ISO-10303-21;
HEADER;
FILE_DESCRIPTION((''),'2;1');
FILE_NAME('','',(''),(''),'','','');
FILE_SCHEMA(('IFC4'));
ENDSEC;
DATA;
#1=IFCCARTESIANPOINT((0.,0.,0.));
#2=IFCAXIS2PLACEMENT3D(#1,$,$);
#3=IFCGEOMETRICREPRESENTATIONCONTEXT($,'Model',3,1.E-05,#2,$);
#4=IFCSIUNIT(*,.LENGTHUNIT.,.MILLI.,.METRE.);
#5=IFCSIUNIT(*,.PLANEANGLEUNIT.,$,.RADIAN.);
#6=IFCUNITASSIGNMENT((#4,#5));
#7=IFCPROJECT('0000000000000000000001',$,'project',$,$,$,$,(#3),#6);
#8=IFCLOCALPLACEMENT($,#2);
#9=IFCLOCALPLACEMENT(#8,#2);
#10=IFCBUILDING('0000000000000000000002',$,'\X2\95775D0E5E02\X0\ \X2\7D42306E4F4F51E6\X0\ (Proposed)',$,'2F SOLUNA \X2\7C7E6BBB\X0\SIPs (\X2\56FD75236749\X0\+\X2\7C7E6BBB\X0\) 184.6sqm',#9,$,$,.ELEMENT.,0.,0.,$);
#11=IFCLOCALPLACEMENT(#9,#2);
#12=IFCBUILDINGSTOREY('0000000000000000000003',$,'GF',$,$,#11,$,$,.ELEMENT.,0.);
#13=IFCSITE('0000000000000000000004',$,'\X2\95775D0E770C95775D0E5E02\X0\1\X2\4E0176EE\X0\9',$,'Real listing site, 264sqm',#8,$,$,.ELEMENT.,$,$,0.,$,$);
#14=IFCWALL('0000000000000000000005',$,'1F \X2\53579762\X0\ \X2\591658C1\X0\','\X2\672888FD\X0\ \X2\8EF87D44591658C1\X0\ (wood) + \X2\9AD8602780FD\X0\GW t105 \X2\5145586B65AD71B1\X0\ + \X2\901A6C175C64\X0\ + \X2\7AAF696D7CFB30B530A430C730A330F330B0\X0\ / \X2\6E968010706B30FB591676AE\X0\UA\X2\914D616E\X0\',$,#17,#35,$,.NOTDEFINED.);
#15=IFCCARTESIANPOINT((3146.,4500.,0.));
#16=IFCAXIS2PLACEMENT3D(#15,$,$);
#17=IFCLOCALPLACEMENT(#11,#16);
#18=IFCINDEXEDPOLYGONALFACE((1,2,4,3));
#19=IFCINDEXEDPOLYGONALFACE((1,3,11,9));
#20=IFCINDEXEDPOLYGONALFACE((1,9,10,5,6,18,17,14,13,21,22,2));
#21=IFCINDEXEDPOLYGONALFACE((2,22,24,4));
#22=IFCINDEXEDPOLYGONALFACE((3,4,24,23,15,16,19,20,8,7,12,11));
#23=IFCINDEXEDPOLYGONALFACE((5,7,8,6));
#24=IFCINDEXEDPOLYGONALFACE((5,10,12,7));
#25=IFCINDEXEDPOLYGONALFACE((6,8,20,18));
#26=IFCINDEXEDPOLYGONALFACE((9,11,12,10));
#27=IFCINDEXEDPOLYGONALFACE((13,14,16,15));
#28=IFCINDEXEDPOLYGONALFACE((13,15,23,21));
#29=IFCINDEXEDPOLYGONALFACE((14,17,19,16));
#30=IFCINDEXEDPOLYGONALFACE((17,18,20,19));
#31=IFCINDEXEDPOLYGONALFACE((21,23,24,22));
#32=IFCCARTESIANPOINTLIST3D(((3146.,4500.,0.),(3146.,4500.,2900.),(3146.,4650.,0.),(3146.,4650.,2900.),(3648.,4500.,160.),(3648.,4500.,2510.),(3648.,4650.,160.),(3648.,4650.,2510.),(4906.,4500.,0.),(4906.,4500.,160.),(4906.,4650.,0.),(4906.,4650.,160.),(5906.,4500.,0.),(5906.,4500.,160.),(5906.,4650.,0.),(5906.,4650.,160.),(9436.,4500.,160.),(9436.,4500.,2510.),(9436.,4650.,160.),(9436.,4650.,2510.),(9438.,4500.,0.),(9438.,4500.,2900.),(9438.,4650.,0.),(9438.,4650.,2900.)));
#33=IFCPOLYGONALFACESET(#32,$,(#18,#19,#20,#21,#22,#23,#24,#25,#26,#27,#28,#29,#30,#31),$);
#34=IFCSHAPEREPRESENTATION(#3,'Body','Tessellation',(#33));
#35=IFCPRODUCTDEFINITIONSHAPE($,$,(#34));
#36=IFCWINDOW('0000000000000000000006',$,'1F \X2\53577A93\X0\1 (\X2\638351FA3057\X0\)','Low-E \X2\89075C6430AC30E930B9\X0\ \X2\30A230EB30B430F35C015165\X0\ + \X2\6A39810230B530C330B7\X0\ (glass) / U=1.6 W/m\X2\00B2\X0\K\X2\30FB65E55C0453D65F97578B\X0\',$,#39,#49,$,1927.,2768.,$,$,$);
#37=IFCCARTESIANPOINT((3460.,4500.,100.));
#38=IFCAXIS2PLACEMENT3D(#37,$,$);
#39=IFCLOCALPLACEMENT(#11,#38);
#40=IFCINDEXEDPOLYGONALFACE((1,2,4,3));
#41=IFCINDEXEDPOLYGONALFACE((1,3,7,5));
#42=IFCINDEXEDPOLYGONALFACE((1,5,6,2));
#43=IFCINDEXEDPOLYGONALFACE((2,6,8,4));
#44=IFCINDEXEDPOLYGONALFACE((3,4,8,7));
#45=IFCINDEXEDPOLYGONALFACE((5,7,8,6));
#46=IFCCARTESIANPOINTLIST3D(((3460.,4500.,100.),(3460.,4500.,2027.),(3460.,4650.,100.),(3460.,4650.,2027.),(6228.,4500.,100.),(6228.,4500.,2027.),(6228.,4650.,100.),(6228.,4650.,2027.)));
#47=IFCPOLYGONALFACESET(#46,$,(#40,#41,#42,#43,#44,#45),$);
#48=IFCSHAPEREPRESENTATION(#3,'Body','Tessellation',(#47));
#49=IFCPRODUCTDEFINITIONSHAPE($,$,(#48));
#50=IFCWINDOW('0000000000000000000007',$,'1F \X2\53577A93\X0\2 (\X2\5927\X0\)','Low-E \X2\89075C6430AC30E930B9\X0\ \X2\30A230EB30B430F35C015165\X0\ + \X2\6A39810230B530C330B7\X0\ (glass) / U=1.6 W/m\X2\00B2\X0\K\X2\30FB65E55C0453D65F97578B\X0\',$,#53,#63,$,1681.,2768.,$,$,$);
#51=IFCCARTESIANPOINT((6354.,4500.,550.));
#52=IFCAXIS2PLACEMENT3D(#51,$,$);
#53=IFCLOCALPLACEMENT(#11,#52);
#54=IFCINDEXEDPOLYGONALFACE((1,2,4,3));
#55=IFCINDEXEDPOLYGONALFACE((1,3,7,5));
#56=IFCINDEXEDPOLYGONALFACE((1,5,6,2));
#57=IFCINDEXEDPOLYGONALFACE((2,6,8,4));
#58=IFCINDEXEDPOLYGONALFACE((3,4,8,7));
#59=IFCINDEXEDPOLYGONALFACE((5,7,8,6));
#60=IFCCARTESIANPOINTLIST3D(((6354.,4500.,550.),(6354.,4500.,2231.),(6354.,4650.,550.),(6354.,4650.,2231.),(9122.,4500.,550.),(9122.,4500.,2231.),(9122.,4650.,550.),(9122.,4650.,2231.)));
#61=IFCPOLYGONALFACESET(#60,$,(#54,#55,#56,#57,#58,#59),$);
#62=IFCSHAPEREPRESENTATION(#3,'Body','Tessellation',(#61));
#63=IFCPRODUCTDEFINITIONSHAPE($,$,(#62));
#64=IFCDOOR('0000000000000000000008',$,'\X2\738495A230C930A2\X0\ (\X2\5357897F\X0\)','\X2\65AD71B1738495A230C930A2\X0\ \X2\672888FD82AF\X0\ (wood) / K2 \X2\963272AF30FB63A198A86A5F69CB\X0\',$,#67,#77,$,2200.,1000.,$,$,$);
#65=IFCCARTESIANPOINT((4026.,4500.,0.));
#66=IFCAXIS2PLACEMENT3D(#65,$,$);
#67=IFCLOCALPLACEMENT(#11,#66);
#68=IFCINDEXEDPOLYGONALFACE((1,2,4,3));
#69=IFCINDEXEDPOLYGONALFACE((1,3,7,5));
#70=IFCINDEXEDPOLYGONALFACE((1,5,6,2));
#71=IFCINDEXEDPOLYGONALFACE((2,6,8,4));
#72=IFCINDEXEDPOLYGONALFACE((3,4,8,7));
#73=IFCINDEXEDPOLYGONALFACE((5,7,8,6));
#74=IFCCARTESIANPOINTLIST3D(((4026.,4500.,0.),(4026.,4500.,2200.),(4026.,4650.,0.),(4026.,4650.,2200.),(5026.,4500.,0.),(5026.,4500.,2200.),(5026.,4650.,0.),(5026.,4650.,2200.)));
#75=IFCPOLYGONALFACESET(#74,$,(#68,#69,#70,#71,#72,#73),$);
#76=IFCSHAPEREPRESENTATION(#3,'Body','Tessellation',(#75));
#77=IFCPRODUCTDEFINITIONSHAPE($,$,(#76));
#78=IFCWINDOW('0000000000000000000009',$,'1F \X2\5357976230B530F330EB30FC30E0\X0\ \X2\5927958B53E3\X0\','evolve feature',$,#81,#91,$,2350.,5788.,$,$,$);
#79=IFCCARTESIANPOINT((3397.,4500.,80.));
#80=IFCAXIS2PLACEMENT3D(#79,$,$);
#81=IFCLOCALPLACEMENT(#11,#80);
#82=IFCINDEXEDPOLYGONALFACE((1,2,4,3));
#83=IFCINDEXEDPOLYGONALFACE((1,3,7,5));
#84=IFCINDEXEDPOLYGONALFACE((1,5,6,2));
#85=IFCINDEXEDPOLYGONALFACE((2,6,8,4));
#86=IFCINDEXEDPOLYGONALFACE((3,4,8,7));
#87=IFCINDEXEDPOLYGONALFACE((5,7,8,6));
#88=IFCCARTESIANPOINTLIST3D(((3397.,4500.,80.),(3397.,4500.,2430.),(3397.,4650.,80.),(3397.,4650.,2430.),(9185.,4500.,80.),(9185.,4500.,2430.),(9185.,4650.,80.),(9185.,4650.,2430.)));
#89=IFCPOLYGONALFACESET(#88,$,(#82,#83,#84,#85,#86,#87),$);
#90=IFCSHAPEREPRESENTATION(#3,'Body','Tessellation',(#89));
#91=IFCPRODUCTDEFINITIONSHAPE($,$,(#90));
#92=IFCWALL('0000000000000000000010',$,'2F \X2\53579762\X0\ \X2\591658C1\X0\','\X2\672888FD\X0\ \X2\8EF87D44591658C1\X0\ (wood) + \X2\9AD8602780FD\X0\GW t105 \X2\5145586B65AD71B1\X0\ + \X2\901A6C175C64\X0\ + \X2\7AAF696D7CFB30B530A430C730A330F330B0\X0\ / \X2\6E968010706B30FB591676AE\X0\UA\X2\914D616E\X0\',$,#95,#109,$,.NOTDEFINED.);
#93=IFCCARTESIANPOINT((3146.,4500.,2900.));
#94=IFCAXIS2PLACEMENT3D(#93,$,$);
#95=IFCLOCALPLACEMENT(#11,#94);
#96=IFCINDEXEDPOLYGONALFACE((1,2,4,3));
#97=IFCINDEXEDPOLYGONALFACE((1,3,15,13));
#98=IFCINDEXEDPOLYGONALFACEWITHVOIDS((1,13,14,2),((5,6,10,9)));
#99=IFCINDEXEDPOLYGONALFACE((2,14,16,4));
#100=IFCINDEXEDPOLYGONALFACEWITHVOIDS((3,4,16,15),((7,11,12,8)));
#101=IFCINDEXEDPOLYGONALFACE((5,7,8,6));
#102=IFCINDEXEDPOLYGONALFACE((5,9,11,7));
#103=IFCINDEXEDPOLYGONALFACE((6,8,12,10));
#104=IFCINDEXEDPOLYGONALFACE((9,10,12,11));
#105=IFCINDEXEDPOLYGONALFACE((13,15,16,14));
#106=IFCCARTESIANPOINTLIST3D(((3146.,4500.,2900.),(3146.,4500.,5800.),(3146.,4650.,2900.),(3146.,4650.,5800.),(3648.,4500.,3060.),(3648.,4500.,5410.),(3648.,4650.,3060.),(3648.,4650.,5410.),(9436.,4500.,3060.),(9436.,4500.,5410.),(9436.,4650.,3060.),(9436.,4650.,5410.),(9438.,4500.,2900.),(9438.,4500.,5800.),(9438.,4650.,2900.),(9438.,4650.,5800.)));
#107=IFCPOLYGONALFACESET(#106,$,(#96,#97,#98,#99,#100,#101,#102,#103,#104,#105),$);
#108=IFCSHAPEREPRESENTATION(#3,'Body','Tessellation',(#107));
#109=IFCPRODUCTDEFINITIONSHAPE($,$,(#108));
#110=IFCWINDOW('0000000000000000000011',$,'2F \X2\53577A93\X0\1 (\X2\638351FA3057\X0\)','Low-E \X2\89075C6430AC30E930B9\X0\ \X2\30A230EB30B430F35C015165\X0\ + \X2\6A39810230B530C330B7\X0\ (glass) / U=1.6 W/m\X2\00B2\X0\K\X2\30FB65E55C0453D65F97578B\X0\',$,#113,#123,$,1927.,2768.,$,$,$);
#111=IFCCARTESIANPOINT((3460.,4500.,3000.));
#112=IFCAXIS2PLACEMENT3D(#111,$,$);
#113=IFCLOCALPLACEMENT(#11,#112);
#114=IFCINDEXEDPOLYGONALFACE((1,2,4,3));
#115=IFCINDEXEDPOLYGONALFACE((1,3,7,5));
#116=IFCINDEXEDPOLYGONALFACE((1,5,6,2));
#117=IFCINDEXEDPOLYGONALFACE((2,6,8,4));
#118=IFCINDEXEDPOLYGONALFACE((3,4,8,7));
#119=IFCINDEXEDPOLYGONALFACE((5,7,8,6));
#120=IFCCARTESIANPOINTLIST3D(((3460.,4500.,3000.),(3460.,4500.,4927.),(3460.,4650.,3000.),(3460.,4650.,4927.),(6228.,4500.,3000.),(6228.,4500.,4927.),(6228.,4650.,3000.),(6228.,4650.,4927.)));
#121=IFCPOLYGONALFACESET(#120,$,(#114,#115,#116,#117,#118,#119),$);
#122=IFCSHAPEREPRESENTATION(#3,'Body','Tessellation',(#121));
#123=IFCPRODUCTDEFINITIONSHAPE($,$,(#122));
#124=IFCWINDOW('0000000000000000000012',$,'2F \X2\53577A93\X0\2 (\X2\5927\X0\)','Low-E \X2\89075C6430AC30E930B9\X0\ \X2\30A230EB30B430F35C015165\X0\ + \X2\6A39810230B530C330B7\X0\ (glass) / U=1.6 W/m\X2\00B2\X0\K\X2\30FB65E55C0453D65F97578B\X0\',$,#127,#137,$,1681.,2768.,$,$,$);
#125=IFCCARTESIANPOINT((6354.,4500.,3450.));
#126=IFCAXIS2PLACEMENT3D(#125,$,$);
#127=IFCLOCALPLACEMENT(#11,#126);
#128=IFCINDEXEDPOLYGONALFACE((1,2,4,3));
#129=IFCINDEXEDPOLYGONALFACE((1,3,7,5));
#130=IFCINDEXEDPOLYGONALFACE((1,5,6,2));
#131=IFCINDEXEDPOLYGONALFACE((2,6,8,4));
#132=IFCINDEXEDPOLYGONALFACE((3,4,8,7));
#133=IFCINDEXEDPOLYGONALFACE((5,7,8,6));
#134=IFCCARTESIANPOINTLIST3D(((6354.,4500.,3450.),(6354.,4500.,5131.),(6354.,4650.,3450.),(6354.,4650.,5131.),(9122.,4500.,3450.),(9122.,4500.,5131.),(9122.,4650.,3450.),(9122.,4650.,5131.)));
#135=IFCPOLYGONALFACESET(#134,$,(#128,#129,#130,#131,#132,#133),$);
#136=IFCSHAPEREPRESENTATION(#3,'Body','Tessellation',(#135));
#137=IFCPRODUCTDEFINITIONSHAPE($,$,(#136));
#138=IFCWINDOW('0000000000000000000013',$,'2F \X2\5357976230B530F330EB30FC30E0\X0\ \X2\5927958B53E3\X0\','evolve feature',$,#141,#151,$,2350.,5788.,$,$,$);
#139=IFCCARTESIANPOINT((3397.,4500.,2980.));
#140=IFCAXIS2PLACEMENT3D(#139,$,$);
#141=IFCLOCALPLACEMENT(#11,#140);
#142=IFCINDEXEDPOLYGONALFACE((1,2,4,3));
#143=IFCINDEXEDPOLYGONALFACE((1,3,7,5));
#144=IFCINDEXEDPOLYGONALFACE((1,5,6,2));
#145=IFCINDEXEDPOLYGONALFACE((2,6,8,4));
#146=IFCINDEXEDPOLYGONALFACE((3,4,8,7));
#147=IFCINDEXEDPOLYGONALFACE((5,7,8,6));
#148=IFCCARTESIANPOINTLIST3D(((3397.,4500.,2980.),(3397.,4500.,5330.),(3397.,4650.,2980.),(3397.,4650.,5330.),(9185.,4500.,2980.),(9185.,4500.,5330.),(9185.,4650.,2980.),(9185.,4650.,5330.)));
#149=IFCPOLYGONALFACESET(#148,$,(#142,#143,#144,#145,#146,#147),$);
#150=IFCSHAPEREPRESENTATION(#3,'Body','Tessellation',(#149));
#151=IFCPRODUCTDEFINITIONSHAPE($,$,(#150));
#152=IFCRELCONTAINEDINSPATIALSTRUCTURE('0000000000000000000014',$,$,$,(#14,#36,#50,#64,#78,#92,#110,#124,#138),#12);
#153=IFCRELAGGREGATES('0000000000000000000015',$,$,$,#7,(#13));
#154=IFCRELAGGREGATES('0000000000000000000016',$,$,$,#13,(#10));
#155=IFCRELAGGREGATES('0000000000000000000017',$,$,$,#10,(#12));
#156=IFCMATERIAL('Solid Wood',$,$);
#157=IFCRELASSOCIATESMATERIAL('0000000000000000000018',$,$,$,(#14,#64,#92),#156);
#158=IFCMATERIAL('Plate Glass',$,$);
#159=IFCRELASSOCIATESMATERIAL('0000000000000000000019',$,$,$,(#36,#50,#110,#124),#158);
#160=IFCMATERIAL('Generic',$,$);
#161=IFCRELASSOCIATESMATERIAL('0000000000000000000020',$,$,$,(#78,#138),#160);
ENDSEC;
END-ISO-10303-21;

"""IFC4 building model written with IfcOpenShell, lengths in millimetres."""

from ifc_helpers import new_model, si_unit, frame, frame_2d, origin, place, context, project, spatial, rectangle, extrude, material, element, fill, save


model = new_model("IFC4")

# Units and contexts
model_context = context("Model", 3, precision=1e-05, world=origin())
ifc_project = project(units=[si_unit("LENGTHUNIT", "METRE", prefix="MILLI"), si_unit("PLANEANGLEUNIT", "RADIAN")], contexts=[model_context])

# Site, building, storey
site_placement = place(None, origin())
site = spatial("IfcSite", under=ifc_project, at=site_placement, Name="長崎県長崎市1丁目9", ObjectType="Real listing site, 264sqm", CompositionType="ELEMENT", RefElevation=0.0)
building_placement = place(site_placement, origin())
building = spatial("IfcBuilding", under=site, at=building_placement, Name="長崎市 終の住処 (Proposed)", ObjectType="2F SOLUNA 籾殻SIPs (国産杉+籾殻) 184.6sqm", CompositionType="ELEMENT", ElevationOfRefHeight=0.0, ElevationOfTerrain=0.0)
storey_placement = place(building_placement, origin())
storey = spatial("IfcBuildingStorey", under=building, at=storey_placement, Name="GF", CompositionType="ELEMENT", Elevation=0.0)

# Shared definitions
ifc_material_1 = material(Name="Solid Wood")
ifc_material_2 = material(Name="Generic")

# Wall, openings, windows, door
wall_1_placement = place(storey_placement, frame((3146.0, 4500.0, 0.0)))
wall_1 = element("IfcWall", 1, at=wall_1_placement, inside=storey, material=ifc_material_1, Name="1F 南面 外壁", Description="木製 軸組外壁 (wood) + 高性能GW t105 充填断熱 + 通気層 + 窯業系サイディング / 準耐火・外皮UA配慮", PredefinedType="NOTDEFINED", context=model_context, shape_type="SweptSolid", body=[
    extrude(rectangle(XDim=6292.0, YDim=150.0, at=frame_2d((3146.0, 75.0))), frame((3146.0, 4500.0, 0.0)), (0.0, 0.0, 1.0), 2900.0),
])
opening_1_placement = place(storey_placement, frame((3460.0, 4500.0, 100.0)))
opening_1 = element("IfcOpeningElement", 2, at=opening_1_placement, cuts=wall_1, PredefinedType="NOTDEFINED", context=model_context, shape_type="SweptSolid", body=[
    extrude(rectangle(XDim=2768.0, YDim=150.0, at=frame_2d((1384.0, 75.0))), frame((3460.0, 4500.0, 100.0)), (0.0, 0.0, 1.0), 1927.0),
])
opening_2_placement = place(storey_placement, frame((6354.0, 4500.0, 550.0)))
opening_2 = element("IfcOpeningElement", 3, at=opening_2_placement, cuts=wall_1, PredefinedType="NOTDEFINED", context=model_context, shape_type="SweptSolid", body=[
    extrude(rectangle(XDim=2768.0, YDim=150.0, at=frame_2d((1384.0, 75.0))), frame((6354.0, 4500.0, 550.0)), (0.0, 0.0, 1.0), 1681.0),
])
opening_3_placement = place(storey_placement, frame((4026.0, 4500.0, 0.0)))
opening_3 = element("IfcOpeningElement", 4, at=opening_3_placement, cuts=wall_1, PredefinedType="NOTDEFINED", context=model_context, shape_type="SweptSolid", body=[
    extrude(rectangle(XDim=1000.0, YDim=150.0, at=frame_2d((500.0, 75.0))), frame((4026.0, 4500.0, 0.0)), (0.0, 0.0, 1.0), 2200.0),
])
opening_4_placement = place(storey_placement, frame((3397.0, 4500.0, 80.0)))
opening_4 = element("IfcOpeningElement", 5, at=opening_4_placement, cuts=wall_1, PredefinedType="NOTDEFINED", context=model_context, shape_type="SweptSolid", body=[
    extrude(rectangle(XDim=5788.0, YDim=150.0, at=frame_2d((2894.0, 75.0))), frame((3397.0, 4500.0, 80.0)), (0.0, 0.0, 1.0), 2350.0),
])
ifc_material_3 = material(Name="Plate Glass")
window_1_placement = place(storey_placement, frame((3460.0, 4500.0, 100.0)))
window_1 = element("IfcWindow", 6, at=window_1_placement, inside=storey, material=ifc_material_3, Name="1F 南窓1 (掃出し)", Description="Low-E 複層ガラス アルゴン封入 + 樹脂サッシ (glass) / U=1.6 W/m²K・日射取得型", OverallHeight=1927.0, OverallWidth=2768.0, context=model_context, shape_type="SweptSolid", body=[
    extrude(rectangle(XDim=2768.0, YDim=150.0, at=frame_2d((1384.0, 75.0))), frame((3460.0, 4500.0, 100.0)), (0.0, 0.0, 1.0), 1927.0),
])
fill(opening_1, window_1)
window_2_placement = place(storey_placement, frame((6354.0, 4500.0, 550.0)))
window_2 = element("IfcWindow", 7, at=window_2_placement, inside=storey, material=ifc_material_3, Name="1F 南窓2 (大)", Description="Low-E 複層ガラス アルゴン封入 + 樹脂サッシ (glass) / U=1.6 W/m²K・日射取得型", OverallHeight=1681.0, OverallWidth=2768.0, context=model_context, shape_type="SweptSolid", body=[
    extrude(rectangle(XDim=2768.0, YDim=150.0, at=frame_2d((1384.0, 75.0))), frame((6354.0, 4500.0, 550.0)), (0.0, 0.0, 1.0), 1681.0),
])
fill(opening_2, window_2)
door_placement = place(storey_placement, frame((4026.0, 4500.0, 0.0)))
door = element("IfcDoor", 8, at=door_placement, inside=storey, material=ifc_material_1, Name="玄関ドア (南西)", Description="断熱玄関ドア 木製芯 (wood) / K2 防犯・採風機構", OverallHeight=2200.0, OverallWidth=1000.0, context=model_context, shape_type="SweptSolid", body=[
    extrude(rectangle(XDim=1000.0, YDim=150.0, at=frame_2d((500.0, 75.0))), frame((4026.0, 4500.0, 0.0)), (0.0, 0.0, 1.0), 2200.0),
])
fill(opening_3, door)
window_3_placement = place(storey_placement, frame((3397.0, 4500.0, 80.0)))
window_3 = element("IfcWindow", 9, at=window_3_placement, inside=storey, material=ifc_material_2, Name="1F 南面サンルーム 大開口", Description="evolve feature", OverallHeight=2350.0, OverallWidth=5788.0, context=model_context, shape_type="SweptSolid", body=[
    extrude(rectangle(XDim=5788.0, YDim=150.0, at=frame_2d((2894.0, 75.0))), frame((3397.0, 4500.0, 80.0)), (0.0, 0.0, 1.0), 2350.0),
])
fill(opening_4, window_3)

# Wall, openings, windows
wall_2_placement = place(storey_placement, frame((3146.0, 4500.0, 2900.0)))
wall_2 = element("IfcWall", 10, at=wall_2_placement, inside=storey, material=ifc_material_1, Name="2F 南面 外壁", Description="木製 軸組外壁 (wood) + 高性能GW t105 充填断熱 + 通気層 + 窯業系サイディング / 準耐火・外皮UA配慮", PredefinedType="NOTDEFINED", context=model_context, shape_type="SweptSolid", body=[
    extrude(rectangle(XDim=6292.0, YDim=150.0, at=frame_2d((3146.0, 75.0))), frame((3146.0, 4500.0, 2900.0)), (0.0, 0.0, 1.0), 2900.0),
])
opening_5_placement = place(storey_placement, frame((3460.0, 4500.0, 3000.0)))
opening_5 = element("IfcOpeningElement", 11, at=opening_5_placement, cuts=wall_2, PredefinedType="NOTDEFINED", context=model_context, shape_type="SweptSolid", body=[
    extrude(rectangle(XDim=2768.0, YDim=150.0, at=frame_2d((1384.0, 75.0))), frame((3460.0, 4500.0, 3000.0)), (0.0, 0.0, 1.0), 1927.0),
])
opening_6_placement = place(storey_placement, frame((6354.0, 4500.0, 3450.0)))
opening_6 = element("IfcOpeningElement", 12, at=opening_6_placement, cuts=wall_2, PredefinedType="NOTDEFINED", context=model_context, shape_type="SweptSolid", body=[
    extrude(rectangle(XDim=2768.0, YDim=150.0, at=frame_2d((1384.0, 75.0))), frame((6354.0, 4500.0, 3450.0)), (0.0, 0.0, 1.0), 1681.0),
])
opening_7_placement = place(storey_placement, frame((3397.0, 4500.0, 2980.0)))
opening_7 = element("IfcOpeningElement", 13, at=opening_7_placement, cuts=wall_2, PredefinedType="NOTDEFINED", context=model_context, shape_type="SweptSolid", body=[
    extrude(rectangle(XDim=5788.0, YDim=150.0, at=frame_2d((2894.0, 75.0))), frame((3397.0, 4500.0, 2980.0)), (0.0, 0.0, 1.0), 2350.0),
])
window_4_placement = place(storey_placement, frame((3460.0, 4500.0, 3000.0)))
window_4 = element("IfcWindow", 14, at=window_4_placement, inside=storey, material=ifc_material_3, Name="2F 南窓1 (掃出し)", Description="Low-E 複層ガラス アルゴン封入 + 樹脂サッシ (glass) / U=1.6 W/m²K・日射取得型", OverallHeight=1927.0, OverallWidth=2768.0, context=model_context, shape_type="SweptSolid", body=[
    extrude(rectangle(XDim=2768.0, YDim=150.0, at=frame_2d((1384.0, 75.0))), frame((3460.0, 4500.0, 3000.0)), (0.0, 0.0, 1.0), 1927.0),
])
fill(opening_5, window_4)
window_5_placement = place(storey_placement, frame((6354.0, 4500.0, 3450.0)))
window_5 = element("IfcWindow", 15, at=window_5_placement, inside=storey, material=ifc_material_3, Name="2F 南窓2 (大)", Description="Low-E 複層ガラス アルゴン封入 + 樹脂サッシ (glass) / U=1.6 W/m²K・日射取得型", OverallHeight=1681.0, OverallWidth=2768.0, context=model_context, shape_type="SweptSolid", body=[
    extrude(rectangle(XDim=2768.0, YDim=150.0, at=frame_2d((1384.0, 75.0))), frame((6354.0, 4500.0, 3450.0)), (0.0, 0.0, 1.0), 1681.0),
])
fill(opening_6, window_5)
window_6_placement = place(storey_placement, frame((3397.0, 4500.0, 2980.0)))
window_6 = element("IfcWindow", 16, at=window_6_placement, inside=storey, material=ifc_material_2, Name="2F 南面サンルーム 大開口", Description="evolve feature", OverallHeight=2350.0, OverallWidth=5788.0, context=model_context, shape_type="SweptSolid", body=[
    extrude(rectangle(XDim=5788.0, YDim=150.0, at=frame_2d((2894.0, 75.0))), frame((3397.0, 4500.0, 2980.0)), (0.0, 0.0, 1.0), 2350.0),
])
fill(opening_7, window_6)

save(model, "model.ifc")
